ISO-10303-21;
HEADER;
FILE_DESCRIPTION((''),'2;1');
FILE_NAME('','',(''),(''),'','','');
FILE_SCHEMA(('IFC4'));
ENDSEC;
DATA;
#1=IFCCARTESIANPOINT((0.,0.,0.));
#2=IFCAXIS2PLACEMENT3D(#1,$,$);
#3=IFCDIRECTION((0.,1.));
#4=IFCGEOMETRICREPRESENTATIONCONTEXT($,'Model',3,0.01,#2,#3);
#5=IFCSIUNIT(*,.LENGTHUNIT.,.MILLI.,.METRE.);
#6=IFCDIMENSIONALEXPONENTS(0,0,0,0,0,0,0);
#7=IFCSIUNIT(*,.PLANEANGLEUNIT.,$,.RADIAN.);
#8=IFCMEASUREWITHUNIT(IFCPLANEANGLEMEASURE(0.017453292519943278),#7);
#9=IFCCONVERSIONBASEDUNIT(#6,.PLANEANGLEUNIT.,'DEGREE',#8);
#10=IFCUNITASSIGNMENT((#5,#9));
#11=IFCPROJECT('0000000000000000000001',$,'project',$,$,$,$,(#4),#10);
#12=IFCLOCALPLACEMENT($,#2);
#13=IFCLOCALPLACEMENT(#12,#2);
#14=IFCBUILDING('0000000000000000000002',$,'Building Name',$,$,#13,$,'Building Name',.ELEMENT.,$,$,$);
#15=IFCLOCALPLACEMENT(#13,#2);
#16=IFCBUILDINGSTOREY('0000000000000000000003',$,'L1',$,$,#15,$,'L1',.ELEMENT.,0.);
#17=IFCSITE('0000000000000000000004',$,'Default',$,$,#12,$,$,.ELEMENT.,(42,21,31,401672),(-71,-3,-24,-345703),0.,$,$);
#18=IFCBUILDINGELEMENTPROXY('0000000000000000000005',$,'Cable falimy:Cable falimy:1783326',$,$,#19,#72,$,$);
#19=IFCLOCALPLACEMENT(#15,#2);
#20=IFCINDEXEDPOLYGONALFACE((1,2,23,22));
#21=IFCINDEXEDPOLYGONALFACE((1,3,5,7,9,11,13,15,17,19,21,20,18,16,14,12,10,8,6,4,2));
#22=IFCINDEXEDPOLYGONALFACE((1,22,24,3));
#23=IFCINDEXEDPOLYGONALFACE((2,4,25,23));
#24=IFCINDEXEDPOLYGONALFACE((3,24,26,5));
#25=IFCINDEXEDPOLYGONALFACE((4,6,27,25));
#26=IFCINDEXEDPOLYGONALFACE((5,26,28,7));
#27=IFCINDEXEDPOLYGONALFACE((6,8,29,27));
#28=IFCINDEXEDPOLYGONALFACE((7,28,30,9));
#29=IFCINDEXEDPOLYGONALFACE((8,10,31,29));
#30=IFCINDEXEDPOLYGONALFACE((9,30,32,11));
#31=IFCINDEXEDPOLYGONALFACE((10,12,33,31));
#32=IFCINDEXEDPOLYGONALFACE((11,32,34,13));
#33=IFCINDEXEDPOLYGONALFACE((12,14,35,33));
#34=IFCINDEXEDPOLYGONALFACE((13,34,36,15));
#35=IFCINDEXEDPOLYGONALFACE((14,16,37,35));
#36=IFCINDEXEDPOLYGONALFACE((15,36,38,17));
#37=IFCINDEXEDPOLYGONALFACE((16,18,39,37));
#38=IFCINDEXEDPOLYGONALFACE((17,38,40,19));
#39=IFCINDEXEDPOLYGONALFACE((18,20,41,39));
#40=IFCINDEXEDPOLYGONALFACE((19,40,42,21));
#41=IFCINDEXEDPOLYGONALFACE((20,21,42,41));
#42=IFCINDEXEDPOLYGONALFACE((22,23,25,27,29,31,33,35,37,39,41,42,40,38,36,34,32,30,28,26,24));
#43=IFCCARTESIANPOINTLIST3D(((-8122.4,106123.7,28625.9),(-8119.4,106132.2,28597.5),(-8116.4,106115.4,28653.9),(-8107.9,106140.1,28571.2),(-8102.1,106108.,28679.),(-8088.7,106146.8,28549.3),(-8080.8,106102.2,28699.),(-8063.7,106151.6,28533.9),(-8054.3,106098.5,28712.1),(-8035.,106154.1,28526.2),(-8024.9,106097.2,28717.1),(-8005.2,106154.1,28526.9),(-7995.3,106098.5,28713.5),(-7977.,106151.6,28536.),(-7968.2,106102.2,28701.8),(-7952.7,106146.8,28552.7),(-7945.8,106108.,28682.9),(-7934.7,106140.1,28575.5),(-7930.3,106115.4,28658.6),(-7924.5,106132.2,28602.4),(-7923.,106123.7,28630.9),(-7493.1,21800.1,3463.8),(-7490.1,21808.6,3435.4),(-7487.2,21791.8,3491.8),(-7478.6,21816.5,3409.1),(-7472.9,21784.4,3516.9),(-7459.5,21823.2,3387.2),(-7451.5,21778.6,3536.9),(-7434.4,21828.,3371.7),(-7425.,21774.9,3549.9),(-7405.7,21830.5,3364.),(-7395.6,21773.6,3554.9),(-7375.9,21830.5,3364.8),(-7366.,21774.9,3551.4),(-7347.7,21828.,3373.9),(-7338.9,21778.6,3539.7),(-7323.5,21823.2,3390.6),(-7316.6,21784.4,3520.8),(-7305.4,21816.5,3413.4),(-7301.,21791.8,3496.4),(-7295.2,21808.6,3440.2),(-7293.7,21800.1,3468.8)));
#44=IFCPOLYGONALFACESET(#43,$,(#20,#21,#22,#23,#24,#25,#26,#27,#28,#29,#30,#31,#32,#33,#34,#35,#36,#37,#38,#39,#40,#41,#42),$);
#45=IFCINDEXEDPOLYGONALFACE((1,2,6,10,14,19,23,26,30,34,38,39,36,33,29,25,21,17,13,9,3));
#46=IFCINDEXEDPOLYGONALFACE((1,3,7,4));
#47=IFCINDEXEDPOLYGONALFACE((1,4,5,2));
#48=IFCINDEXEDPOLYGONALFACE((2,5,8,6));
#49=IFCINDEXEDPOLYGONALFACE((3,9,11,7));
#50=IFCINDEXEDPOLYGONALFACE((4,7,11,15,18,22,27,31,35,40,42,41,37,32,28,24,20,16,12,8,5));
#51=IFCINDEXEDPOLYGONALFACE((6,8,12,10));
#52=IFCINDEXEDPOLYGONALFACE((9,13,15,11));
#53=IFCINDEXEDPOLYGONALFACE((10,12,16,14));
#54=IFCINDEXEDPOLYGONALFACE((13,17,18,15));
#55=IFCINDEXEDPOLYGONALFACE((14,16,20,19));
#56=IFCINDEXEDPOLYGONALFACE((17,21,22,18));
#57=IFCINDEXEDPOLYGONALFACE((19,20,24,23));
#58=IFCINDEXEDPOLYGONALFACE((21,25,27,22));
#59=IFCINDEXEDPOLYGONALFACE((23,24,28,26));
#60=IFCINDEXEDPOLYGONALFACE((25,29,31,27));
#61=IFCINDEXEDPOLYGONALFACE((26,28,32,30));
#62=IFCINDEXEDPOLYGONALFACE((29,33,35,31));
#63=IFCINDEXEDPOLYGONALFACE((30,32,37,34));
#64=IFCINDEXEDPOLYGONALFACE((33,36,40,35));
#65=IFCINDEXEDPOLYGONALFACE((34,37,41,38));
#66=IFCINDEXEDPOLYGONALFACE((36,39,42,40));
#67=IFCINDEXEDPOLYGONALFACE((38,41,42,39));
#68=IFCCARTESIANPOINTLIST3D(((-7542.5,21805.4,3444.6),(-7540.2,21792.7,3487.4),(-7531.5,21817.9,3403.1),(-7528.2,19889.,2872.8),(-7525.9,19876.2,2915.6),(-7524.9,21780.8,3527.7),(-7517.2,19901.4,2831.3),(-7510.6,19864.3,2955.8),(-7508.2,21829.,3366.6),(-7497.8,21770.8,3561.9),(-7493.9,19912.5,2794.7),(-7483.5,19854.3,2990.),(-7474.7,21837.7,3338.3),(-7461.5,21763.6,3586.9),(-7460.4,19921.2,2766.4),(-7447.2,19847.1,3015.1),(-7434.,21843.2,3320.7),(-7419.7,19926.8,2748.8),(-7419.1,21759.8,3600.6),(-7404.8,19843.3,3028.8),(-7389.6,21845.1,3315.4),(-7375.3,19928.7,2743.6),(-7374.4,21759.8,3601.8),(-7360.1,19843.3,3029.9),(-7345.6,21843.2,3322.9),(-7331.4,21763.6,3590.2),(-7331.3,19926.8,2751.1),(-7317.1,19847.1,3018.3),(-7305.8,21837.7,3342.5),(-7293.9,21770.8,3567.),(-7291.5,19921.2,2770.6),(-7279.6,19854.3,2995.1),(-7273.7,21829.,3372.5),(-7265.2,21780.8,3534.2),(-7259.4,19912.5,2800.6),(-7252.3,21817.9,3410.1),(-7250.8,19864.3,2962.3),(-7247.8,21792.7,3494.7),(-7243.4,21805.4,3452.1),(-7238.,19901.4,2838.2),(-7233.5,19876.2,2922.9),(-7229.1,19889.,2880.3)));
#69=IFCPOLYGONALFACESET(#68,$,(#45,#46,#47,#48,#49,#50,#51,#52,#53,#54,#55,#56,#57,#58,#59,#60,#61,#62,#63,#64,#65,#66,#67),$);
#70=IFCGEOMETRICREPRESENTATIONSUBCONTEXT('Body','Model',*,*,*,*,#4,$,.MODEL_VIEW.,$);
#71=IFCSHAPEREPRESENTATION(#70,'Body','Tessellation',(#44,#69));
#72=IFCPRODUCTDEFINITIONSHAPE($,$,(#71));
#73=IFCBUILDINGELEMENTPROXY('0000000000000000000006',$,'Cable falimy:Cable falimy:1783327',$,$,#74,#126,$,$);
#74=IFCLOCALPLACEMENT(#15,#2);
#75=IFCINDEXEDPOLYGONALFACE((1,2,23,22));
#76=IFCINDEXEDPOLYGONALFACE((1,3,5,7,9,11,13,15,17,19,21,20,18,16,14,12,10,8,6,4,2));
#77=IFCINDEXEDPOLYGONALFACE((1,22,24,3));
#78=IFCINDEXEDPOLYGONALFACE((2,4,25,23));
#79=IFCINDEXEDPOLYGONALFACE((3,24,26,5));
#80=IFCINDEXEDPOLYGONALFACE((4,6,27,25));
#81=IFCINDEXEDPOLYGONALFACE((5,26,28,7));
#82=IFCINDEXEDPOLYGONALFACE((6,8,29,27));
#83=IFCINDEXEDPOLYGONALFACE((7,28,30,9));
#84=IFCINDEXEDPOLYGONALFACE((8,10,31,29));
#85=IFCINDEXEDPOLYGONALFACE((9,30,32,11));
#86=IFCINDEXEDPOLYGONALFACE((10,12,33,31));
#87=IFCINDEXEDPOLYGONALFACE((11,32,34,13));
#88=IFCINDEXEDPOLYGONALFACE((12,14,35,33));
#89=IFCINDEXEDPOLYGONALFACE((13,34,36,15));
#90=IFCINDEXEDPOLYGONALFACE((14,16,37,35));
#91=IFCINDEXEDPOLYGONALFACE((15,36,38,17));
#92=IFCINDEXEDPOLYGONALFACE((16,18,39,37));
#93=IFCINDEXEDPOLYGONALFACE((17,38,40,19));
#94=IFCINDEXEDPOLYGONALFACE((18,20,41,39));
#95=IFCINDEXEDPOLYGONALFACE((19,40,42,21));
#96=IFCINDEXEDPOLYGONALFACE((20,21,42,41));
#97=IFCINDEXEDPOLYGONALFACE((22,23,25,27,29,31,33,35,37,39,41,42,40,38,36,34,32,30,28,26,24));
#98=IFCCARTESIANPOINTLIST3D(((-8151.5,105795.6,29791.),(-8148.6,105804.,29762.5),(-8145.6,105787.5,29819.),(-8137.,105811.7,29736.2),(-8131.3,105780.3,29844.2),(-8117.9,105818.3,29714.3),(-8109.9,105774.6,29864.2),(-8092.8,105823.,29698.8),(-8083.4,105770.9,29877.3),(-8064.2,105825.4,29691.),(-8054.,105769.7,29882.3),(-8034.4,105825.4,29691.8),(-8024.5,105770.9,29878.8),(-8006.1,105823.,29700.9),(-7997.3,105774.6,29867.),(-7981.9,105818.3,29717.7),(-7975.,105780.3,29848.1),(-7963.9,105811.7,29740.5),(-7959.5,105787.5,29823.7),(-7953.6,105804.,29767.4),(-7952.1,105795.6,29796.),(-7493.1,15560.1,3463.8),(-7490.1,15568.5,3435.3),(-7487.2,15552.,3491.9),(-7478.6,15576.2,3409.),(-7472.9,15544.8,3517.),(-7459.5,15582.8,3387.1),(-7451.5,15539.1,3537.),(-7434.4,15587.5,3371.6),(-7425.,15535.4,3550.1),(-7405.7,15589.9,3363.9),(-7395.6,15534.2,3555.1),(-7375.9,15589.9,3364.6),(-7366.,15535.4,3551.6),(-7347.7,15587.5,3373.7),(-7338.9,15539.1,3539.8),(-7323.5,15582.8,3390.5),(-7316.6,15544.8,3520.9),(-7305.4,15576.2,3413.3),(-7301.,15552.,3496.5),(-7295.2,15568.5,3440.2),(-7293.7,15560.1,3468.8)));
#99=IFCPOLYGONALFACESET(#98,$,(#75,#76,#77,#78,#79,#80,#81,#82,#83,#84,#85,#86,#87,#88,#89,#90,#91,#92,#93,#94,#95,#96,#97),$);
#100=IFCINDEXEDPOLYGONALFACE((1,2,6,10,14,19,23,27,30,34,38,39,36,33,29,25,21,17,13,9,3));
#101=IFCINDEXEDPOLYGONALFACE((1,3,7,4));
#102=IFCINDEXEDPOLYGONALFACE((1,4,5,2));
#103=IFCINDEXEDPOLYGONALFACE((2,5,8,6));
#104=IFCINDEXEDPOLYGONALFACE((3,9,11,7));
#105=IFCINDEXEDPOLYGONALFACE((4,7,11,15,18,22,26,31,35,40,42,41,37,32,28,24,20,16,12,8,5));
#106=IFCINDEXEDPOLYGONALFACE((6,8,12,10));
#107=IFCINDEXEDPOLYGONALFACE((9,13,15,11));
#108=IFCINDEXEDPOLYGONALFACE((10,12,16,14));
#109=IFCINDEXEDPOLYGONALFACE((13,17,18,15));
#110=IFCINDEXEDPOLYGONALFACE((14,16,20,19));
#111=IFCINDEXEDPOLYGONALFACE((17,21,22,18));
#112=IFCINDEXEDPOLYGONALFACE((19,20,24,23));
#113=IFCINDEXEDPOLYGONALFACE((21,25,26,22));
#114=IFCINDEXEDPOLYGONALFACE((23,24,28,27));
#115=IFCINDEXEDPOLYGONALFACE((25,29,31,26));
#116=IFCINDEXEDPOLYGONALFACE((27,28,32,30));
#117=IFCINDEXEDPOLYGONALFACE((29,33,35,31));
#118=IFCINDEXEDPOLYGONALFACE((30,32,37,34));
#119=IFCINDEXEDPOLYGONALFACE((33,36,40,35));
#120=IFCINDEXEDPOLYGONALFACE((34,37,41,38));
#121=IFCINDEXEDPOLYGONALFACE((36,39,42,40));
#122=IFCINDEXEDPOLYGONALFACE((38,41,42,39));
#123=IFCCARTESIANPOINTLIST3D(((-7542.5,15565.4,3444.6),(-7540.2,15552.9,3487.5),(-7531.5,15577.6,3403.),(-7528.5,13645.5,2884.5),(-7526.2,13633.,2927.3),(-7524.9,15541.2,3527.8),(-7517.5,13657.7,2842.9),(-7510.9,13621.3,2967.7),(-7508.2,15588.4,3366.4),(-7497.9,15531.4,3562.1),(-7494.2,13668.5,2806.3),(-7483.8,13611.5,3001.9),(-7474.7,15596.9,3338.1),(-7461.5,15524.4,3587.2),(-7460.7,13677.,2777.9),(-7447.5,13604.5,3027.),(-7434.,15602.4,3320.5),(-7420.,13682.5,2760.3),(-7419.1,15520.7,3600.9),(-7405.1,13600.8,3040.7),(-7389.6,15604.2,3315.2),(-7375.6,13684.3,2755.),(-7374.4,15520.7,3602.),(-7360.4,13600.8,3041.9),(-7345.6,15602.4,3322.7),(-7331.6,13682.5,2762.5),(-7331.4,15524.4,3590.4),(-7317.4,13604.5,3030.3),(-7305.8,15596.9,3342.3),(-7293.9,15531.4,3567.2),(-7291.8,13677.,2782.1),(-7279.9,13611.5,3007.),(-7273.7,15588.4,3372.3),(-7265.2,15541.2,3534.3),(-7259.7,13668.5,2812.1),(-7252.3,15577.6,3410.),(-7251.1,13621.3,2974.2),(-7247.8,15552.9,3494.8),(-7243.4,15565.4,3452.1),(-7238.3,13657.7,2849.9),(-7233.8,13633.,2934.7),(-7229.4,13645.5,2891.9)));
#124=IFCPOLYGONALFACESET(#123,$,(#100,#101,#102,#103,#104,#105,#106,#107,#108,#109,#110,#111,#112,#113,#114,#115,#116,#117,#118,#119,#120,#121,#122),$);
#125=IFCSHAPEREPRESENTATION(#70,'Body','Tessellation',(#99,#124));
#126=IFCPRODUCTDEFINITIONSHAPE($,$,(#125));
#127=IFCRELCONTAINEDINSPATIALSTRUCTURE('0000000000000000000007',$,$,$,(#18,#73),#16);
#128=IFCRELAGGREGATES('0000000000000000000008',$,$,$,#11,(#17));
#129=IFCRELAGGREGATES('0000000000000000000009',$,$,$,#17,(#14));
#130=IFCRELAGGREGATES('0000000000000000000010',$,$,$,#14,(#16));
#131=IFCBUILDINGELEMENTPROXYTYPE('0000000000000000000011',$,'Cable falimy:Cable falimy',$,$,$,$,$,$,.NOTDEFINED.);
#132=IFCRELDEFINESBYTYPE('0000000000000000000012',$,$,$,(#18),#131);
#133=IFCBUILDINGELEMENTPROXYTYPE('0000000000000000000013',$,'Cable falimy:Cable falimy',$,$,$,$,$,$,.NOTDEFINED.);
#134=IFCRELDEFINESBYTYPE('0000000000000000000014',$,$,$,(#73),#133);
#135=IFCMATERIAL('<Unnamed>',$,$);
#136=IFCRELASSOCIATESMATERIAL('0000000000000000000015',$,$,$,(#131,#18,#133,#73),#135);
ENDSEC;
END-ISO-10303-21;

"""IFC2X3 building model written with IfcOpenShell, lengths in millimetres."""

from ifc_helpers import new_model, entity, si_unit, converted_unit, direction, frame, frame_2d, origin, place, context, subcontext, project, spatial, circle, extrude, source, transform, mapped, material, type_object, type_shapes, element, save


model = new_model("IFC2X3")

# Units and contexts
model_context = context("Model", 3, precision=0.01, world=origin(), true_north=direction((0.0, 1.0)))
body_context = subcontext(model_context, "Body", "Model", "MODEL_VIEW")
ifc_project = project(units=[si_unit("LENGTHUNIT", "METRE", prefix="MILLI"), converted_unit("PLANEANGLEUNIT", "DEGREE", entity("IfcPlaneAngleMeasure", 0.017453292519943278), si_unit("PLANEANGLEUNIT", "RADIAN"), dimensions=[0, 0, 0, 0, 0, 0, 0])], contexts=[model_context])

# Site, building, storey
site_placement = place(None, origin())
site = spatial("IfcSite", under=ifc_project, at=site_placement, Name="Default", CompositionType="ELEMENT", RefLatitude=(42, 21, 31, 401672), RefLongitude=(-71, -3, -24, -345703), RefElevation=0.0)
building_placement = place(site_placement, origin())
building = spatial("IfcBuilding", under=site, at=building_placement, Name="Building Name", LongName="Building Name", CompositionType="ELEMENT")
storey_placement = place(building_placement, origin())
storey = spatial("IfcBuildingStorey", under=building, at=storey_placement, Name="L1", LongName="L1", CompositionType="ELEMENT", Elevation=0.0)

# Shared definitions
ifc_material = material(Name="<Unnamed>")

# Building element proxies
building_element_proxy_type_1 = type_object("IfcBuildingElementProxyType", Name="Cable falimy:Cable falimy", PredefinedType="NOTDEFINED", material=ifc_material)
shared_shape_1 = source(origin(), body_context, "Body", "SweptSolid", [
    extrude(circle(Radius=100.0, at=frame_2d((0.0, 0.0), x_axis=(1.0, 0.0))), frame((0.0, 0.0, 0.0), z_axis=(0.958223, 0.0, 0.286023), x_axis=(-0.286023, 0.0, 0.958223)), (0.0, 0.0, 1.0), 88000.0),
    extrude(circle(Radius=150.0, at=frame_2d((0.0, 0.0), x_axis=(1.0, 0.0))), frame((-1916.4, 0.0, -572.0), z_axis=(0.958223, 0.0, 0.286023), x_axis=(0.286023, 0.0, -0.958223)), (0.0, 0.0, 1.0), 2000.0),
])
type_shapes(building_element_proxy_type_1, [shared_shape_1])
proxy_1_placement = place(storey_placement, frame((-7393.2, 21802.2, 3459.1), z_axis=(-0.025001, 0.0, 0.999687), x_axis=(0.0, 1.0, 0.0)))
element("IfcBuildingElementProxy", 1, at=proxy_1_placement, inside=storey, type_object=building_element_proxy_type_1, material=ifc_material, Name="Cable falimy:Cable falimy:1783326", context=body_context, shape_type="MappedRepresentation", body=[
    mapped(shared_shape_1, transform((0.0, 0.0, 0.0), scale=1.0)),
])
building_element_proxy_type_2 = type_object("IfcBuildingElementProxyType", Name="Cable falimy:Cable falimy", PredefinedType="NOTDEFINED", material=ifc_material)
shared_shape_2 = source(origin(), body_context, "Body", "SweptSolid", [
    extrude(circle(Radius=100.0, at=frame_2d((0.0, 0.0), x_axis=(1.0, 0.0))), frame((0.0, 0.0, 0.0), z_axis=(0.959952, 0.0, 0.280164), x_axis=(-0.280164, 0.0, 0.959952)), (0.0, 0.0, 1.0), 94000.0),
    extrude(circle(Radius=150.0, at=frame_2d((0.0, 0.0), x_axis=(1.0, 0.0))), frame((-1919.9, 0.0, -560.3), z_axis=(0.959952, 0.0, 0.280164), x_axis=(0.280164, 0.0, -0.959952)), (0.0, 0.0, 1.0), 2000.0),
])
type_shapes(building_element_proxy_type_2, [shared_shape_2])
proxy_2_placement = place(storey_placement, frame((-7393.2, 15562.2, 3459.1), z_axis=(-0.025001, 0.0, 0.999687), x_axis=(0.0, 1.0, 0.0)))
element("IfcBuildingElementProxy", 2, at=proxy_2_placement, inside=storey, type_object=building_element_proxy_type_2, material=ifc_material, Name="Cable falimy:Cable falimy:1783327", context=body_context, shape_type="MappedRepresentation", body=[
    mapped(shared_shape_2, transform((0.0, 0.0, 0.0), scale=1.0)),
])

save(model, "model.ifc")
